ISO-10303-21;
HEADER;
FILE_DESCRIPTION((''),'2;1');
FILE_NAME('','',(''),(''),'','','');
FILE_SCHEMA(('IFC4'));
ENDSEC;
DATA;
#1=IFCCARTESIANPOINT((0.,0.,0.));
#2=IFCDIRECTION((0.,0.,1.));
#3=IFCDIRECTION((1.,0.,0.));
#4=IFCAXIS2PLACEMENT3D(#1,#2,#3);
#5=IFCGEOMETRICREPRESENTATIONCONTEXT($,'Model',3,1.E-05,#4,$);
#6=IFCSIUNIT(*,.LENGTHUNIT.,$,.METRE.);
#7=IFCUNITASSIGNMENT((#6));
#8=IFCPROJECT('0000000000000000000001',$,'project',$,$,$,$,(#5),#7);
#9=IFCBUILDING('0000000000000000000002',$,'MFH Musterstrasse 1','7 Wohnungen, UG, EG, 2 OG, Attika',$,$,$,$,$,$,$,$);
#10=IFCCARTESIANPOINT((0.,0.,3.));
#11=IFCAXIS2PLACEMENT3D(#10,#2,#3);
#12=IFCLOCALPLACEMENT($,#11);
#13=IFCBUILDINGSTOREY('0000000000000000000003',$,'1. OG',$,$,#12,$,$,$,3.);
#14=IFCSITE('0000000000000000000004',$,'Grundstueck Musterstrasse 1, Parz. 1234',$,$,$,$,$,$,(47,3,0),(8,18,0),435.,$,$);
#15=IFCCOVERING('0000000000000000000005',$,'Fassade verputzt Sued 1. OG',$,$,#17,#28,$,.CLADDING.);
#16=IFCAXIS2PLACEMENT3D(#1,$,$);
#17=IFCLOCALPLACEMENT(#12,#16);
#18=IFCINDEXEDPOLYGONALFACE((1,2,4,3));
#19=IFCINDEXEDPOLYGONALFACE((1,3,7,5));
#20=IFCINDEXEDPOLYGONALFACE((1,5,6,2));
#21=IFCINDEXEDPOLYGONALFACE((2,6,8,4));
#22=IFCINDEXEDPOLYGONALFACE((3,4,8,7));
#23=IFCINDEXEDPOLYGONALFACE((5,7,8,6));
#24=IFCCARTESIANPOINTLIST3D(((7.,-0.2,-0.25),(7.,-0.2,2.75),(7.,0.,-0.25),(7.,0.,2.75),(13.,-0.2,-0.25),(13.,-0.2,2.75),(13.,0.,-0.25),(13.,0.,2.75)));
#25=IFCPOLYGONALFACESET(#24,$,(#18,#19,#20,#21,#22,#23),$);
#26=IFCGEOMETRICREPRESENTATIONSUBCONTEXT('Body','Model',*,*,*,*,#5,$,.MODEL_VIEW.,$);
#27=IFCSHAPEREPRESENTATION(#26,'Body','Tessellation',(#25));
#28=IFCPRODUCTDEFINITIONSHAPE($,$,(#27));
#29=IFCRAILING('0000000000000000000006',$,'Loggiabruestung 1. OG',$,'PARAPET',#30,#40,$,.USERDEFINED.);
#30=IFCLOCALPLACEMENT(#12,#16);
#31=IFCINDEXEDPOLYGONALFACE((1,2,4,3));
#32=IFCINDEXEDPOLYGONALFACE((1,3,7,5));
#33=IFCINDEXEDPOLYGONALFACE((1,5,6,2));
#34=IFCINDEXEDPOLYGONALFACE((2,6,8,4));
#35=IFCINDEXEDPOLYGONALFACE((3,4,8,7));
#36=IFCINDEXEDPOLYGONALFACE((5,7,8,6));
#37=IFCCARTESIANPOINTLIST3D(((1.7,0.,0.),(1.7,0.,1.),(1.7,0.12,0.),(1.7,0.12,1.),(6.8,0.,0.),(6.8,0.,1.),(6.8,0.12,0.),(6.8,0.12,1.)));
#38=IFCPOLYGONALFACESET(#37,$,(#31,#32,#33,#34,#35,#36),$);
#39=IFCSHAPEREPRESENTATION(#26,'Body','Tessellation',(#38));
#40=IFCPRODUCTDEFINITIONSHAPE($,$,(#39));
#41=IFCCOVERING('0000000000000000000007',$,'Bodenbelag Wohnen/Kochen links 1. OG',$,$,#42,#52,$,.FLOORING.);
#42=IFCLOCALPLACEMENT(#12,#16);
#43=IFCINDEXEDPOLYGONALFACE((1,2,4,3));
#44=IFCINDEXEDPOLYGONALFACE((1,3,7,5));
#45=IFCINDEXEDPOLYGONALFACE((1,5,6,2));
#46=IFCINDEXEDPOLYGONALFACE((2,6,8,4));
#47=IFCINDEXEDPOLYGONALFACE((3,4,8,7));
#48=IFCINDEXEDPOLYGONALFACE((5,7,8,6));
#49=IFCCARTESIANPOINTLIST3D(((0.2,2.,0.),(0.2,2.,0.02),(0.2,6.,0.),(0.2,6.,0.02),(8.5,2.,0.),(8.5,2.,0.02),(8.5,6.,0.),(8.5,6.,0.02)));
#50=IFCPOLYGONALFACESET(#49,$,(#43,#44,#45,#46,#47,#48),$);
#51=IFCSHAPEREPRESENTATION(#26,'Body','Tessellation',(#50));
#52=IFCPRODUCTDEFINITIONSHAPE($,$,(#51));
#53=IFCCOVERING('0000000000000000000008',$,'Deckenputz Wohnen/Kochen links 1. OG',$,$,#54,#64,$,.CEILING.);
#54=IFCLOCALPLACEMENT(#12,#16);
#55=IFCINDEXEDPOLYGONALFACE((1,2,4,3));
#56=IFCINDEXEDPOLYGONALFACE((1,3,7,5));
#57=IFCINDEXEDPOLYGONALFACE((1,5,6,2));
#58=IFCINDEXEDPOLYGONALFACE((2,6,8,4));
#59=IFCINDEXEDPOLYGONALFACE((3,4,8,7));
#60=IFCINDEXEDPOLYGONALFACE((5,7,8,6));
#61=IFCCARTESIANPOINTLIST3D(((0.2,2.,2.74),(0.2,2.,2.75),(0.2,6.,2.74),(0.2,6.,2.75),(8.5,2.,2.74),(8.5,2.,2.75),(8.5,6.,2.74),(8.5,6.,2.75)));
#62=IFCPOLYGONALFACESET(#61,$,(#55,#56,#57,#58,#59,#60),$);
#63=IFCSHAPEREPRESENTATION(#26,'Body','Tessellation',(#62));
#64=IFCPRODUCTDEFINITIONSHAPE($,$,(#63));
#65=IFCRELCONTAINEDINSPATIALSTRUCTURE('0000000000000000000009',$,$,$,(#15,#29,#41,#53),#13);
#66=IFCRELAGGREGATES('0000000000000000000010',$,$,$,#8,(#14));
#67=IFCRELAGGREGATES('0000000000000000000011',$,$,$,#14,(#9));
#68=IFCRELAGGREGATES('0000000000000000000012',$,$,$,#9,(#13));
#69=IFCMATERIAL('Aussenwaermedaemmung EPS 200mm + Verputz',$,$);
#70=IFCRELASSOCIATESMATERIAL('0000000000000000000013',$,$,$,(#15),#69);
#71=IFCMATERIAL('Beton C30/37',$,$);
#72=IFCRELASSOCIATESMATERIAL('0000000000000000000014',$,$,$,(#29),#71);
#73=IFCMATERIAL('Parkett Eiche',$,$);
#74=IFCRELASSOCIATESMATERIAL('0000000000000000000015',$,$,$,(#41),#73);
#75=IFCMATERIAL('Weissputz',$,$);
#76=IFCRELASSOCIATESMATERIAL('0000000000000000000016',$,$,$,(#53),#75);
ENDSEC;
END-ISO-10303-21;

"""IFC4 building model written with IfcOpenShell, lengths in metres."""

from ifc_helpers import new_model, si_unit, frame, frame_2d, origin_with_axes, place, context, subcontext, project, spatial, rectangle, extrude, material, element, save


model = new_model("IFC4")

# Units and contexts
model_context = context("Model", 3, precision=1e-05, world=origin_with_axes())
body_context = subcontext(model_context, "Body", "Model", "MODEL_VIEW")
ifc_project = project(units=[si_unit("LENGTHUNIT", "METRE")], contexts=[model_context])

# Site, building, storey
site = spatial("IfcSite", under=ifc_project, Name="Grundstueck Musterstrasse 1, Parz. 1234", RefLatitude=(47, 3, 0), RefLongitude=(8, 18, 0), RefElevation=435.0)
building = spatial("IfcBuilding", under=site, Name="MFH Musterstrasse 1", Description="7 Wohnungen, UG, EG, 2 OG, Attika")
storey_placement = place(None, frame((0.0, 0.0, 3.0), z_axis=(0.0, 0.0, 1.0), x_axis=(1.0, 0.0, 0.0)))
storey = spatial("IfcBuildingStorey", under=building, at=storey_placement, Name="1. OG", Elevation=3.0)

# Shared definitions
ifc_material_1 = material(Name="Aussenwaermedaemmung EPS 200mm + Verputz")

# Covering
covering_1_placement = place(storey_placement, frame((7.0, -0.2, -0.25), z_axis=(0.0, 0.0, 1.0), x_axis=(1.0, 0.0, 0.0)))
element("IfcCovering", 1, at=covering_1_placement, inside=storey, material=ifc_material_1, Name="Fassade verputzt Sued 1. OG", PredefinedType="CLADDING", context=body_context, shape_type="SweptSolid", body=[
    extrude(rectangle(XDim=6.0, YDim=0.2, at=frame_2d((3.0, 0.1))), origin_with_axes(), (0.0, 0.0, 1.0), 3.0),
])

# Railing
ifc_material_2 = material(Name="Beton C30/37")
railing_placement = place(storey_placement, frame((1.7, 0.0, 0.0), z_axis=(0.0, 0.0, 1.0), x_axis=(1.0, 0.0, 0.0)))
element("IfcRailing", 2, at=railing_placement, inside=storey, material=ifc_material_2, Name="Loggiabruestung 1. OG", ObjectType="PARAPET", PredefinedType="USERDEFINED", context=body_context, shape_type="SweptSolid", body=[
    extrude(rectangle(XDim=5.1, YDim=0.12, at=frame_2d((2.55, 0.06))), origin_with_axes(), (0.0, 0.0, 1.0), 1.0),
])

# Coverings
ifc_material_3 = material(Name="Parkett Eiche")
covering_2_placement = place(storey_placement, frame((0.2, 2.0, 0.0), z_axis=(0.0, 0.0, 1.0), x_axis=(1.0, 0.0, 0.0)))
element("IfcCovering", 3, at=covering_2_placement, inside=storey, material=ifc_material_3, Name="Bodenbelag Wohnen/Kochen links 1. OG", PredefinedType="FLOORING", context=body_context, shape_type="SweptSolid", body=[
    extrude(rectangle(XDim=8.3, YDim=4.0, at=frame_2d((4.15, 2.0))), origin_with_axes(), (0.0, 0.0, 1.0), 0.02),
])
ifc_material_4 = material(Name="Weissputz")
covering_3_placement = place(storey_placement, frame((0.2, 2.0, 2.74), z_axis=(0.0, 0.0, 1.0), x_axis=(1.0, 0.0, 0.0)))
element("IfcCovering", 4, at=covering_3_placement, inside=storey, material=ifc_material_4, Name="Deckenputz Wohnen/Kochen links 1. OG", PredefinedType="CEILING", context=body_context, shape_type="SweptSolid", body=[
    extrude(rectangle(XDim=8.3, YDim=4.0, at=frame_2d((4.15, 2.0))), origin_with_axes(), (0.0, 0.0, 1.0), 0.01),
])

save(model, "model.ifc")
